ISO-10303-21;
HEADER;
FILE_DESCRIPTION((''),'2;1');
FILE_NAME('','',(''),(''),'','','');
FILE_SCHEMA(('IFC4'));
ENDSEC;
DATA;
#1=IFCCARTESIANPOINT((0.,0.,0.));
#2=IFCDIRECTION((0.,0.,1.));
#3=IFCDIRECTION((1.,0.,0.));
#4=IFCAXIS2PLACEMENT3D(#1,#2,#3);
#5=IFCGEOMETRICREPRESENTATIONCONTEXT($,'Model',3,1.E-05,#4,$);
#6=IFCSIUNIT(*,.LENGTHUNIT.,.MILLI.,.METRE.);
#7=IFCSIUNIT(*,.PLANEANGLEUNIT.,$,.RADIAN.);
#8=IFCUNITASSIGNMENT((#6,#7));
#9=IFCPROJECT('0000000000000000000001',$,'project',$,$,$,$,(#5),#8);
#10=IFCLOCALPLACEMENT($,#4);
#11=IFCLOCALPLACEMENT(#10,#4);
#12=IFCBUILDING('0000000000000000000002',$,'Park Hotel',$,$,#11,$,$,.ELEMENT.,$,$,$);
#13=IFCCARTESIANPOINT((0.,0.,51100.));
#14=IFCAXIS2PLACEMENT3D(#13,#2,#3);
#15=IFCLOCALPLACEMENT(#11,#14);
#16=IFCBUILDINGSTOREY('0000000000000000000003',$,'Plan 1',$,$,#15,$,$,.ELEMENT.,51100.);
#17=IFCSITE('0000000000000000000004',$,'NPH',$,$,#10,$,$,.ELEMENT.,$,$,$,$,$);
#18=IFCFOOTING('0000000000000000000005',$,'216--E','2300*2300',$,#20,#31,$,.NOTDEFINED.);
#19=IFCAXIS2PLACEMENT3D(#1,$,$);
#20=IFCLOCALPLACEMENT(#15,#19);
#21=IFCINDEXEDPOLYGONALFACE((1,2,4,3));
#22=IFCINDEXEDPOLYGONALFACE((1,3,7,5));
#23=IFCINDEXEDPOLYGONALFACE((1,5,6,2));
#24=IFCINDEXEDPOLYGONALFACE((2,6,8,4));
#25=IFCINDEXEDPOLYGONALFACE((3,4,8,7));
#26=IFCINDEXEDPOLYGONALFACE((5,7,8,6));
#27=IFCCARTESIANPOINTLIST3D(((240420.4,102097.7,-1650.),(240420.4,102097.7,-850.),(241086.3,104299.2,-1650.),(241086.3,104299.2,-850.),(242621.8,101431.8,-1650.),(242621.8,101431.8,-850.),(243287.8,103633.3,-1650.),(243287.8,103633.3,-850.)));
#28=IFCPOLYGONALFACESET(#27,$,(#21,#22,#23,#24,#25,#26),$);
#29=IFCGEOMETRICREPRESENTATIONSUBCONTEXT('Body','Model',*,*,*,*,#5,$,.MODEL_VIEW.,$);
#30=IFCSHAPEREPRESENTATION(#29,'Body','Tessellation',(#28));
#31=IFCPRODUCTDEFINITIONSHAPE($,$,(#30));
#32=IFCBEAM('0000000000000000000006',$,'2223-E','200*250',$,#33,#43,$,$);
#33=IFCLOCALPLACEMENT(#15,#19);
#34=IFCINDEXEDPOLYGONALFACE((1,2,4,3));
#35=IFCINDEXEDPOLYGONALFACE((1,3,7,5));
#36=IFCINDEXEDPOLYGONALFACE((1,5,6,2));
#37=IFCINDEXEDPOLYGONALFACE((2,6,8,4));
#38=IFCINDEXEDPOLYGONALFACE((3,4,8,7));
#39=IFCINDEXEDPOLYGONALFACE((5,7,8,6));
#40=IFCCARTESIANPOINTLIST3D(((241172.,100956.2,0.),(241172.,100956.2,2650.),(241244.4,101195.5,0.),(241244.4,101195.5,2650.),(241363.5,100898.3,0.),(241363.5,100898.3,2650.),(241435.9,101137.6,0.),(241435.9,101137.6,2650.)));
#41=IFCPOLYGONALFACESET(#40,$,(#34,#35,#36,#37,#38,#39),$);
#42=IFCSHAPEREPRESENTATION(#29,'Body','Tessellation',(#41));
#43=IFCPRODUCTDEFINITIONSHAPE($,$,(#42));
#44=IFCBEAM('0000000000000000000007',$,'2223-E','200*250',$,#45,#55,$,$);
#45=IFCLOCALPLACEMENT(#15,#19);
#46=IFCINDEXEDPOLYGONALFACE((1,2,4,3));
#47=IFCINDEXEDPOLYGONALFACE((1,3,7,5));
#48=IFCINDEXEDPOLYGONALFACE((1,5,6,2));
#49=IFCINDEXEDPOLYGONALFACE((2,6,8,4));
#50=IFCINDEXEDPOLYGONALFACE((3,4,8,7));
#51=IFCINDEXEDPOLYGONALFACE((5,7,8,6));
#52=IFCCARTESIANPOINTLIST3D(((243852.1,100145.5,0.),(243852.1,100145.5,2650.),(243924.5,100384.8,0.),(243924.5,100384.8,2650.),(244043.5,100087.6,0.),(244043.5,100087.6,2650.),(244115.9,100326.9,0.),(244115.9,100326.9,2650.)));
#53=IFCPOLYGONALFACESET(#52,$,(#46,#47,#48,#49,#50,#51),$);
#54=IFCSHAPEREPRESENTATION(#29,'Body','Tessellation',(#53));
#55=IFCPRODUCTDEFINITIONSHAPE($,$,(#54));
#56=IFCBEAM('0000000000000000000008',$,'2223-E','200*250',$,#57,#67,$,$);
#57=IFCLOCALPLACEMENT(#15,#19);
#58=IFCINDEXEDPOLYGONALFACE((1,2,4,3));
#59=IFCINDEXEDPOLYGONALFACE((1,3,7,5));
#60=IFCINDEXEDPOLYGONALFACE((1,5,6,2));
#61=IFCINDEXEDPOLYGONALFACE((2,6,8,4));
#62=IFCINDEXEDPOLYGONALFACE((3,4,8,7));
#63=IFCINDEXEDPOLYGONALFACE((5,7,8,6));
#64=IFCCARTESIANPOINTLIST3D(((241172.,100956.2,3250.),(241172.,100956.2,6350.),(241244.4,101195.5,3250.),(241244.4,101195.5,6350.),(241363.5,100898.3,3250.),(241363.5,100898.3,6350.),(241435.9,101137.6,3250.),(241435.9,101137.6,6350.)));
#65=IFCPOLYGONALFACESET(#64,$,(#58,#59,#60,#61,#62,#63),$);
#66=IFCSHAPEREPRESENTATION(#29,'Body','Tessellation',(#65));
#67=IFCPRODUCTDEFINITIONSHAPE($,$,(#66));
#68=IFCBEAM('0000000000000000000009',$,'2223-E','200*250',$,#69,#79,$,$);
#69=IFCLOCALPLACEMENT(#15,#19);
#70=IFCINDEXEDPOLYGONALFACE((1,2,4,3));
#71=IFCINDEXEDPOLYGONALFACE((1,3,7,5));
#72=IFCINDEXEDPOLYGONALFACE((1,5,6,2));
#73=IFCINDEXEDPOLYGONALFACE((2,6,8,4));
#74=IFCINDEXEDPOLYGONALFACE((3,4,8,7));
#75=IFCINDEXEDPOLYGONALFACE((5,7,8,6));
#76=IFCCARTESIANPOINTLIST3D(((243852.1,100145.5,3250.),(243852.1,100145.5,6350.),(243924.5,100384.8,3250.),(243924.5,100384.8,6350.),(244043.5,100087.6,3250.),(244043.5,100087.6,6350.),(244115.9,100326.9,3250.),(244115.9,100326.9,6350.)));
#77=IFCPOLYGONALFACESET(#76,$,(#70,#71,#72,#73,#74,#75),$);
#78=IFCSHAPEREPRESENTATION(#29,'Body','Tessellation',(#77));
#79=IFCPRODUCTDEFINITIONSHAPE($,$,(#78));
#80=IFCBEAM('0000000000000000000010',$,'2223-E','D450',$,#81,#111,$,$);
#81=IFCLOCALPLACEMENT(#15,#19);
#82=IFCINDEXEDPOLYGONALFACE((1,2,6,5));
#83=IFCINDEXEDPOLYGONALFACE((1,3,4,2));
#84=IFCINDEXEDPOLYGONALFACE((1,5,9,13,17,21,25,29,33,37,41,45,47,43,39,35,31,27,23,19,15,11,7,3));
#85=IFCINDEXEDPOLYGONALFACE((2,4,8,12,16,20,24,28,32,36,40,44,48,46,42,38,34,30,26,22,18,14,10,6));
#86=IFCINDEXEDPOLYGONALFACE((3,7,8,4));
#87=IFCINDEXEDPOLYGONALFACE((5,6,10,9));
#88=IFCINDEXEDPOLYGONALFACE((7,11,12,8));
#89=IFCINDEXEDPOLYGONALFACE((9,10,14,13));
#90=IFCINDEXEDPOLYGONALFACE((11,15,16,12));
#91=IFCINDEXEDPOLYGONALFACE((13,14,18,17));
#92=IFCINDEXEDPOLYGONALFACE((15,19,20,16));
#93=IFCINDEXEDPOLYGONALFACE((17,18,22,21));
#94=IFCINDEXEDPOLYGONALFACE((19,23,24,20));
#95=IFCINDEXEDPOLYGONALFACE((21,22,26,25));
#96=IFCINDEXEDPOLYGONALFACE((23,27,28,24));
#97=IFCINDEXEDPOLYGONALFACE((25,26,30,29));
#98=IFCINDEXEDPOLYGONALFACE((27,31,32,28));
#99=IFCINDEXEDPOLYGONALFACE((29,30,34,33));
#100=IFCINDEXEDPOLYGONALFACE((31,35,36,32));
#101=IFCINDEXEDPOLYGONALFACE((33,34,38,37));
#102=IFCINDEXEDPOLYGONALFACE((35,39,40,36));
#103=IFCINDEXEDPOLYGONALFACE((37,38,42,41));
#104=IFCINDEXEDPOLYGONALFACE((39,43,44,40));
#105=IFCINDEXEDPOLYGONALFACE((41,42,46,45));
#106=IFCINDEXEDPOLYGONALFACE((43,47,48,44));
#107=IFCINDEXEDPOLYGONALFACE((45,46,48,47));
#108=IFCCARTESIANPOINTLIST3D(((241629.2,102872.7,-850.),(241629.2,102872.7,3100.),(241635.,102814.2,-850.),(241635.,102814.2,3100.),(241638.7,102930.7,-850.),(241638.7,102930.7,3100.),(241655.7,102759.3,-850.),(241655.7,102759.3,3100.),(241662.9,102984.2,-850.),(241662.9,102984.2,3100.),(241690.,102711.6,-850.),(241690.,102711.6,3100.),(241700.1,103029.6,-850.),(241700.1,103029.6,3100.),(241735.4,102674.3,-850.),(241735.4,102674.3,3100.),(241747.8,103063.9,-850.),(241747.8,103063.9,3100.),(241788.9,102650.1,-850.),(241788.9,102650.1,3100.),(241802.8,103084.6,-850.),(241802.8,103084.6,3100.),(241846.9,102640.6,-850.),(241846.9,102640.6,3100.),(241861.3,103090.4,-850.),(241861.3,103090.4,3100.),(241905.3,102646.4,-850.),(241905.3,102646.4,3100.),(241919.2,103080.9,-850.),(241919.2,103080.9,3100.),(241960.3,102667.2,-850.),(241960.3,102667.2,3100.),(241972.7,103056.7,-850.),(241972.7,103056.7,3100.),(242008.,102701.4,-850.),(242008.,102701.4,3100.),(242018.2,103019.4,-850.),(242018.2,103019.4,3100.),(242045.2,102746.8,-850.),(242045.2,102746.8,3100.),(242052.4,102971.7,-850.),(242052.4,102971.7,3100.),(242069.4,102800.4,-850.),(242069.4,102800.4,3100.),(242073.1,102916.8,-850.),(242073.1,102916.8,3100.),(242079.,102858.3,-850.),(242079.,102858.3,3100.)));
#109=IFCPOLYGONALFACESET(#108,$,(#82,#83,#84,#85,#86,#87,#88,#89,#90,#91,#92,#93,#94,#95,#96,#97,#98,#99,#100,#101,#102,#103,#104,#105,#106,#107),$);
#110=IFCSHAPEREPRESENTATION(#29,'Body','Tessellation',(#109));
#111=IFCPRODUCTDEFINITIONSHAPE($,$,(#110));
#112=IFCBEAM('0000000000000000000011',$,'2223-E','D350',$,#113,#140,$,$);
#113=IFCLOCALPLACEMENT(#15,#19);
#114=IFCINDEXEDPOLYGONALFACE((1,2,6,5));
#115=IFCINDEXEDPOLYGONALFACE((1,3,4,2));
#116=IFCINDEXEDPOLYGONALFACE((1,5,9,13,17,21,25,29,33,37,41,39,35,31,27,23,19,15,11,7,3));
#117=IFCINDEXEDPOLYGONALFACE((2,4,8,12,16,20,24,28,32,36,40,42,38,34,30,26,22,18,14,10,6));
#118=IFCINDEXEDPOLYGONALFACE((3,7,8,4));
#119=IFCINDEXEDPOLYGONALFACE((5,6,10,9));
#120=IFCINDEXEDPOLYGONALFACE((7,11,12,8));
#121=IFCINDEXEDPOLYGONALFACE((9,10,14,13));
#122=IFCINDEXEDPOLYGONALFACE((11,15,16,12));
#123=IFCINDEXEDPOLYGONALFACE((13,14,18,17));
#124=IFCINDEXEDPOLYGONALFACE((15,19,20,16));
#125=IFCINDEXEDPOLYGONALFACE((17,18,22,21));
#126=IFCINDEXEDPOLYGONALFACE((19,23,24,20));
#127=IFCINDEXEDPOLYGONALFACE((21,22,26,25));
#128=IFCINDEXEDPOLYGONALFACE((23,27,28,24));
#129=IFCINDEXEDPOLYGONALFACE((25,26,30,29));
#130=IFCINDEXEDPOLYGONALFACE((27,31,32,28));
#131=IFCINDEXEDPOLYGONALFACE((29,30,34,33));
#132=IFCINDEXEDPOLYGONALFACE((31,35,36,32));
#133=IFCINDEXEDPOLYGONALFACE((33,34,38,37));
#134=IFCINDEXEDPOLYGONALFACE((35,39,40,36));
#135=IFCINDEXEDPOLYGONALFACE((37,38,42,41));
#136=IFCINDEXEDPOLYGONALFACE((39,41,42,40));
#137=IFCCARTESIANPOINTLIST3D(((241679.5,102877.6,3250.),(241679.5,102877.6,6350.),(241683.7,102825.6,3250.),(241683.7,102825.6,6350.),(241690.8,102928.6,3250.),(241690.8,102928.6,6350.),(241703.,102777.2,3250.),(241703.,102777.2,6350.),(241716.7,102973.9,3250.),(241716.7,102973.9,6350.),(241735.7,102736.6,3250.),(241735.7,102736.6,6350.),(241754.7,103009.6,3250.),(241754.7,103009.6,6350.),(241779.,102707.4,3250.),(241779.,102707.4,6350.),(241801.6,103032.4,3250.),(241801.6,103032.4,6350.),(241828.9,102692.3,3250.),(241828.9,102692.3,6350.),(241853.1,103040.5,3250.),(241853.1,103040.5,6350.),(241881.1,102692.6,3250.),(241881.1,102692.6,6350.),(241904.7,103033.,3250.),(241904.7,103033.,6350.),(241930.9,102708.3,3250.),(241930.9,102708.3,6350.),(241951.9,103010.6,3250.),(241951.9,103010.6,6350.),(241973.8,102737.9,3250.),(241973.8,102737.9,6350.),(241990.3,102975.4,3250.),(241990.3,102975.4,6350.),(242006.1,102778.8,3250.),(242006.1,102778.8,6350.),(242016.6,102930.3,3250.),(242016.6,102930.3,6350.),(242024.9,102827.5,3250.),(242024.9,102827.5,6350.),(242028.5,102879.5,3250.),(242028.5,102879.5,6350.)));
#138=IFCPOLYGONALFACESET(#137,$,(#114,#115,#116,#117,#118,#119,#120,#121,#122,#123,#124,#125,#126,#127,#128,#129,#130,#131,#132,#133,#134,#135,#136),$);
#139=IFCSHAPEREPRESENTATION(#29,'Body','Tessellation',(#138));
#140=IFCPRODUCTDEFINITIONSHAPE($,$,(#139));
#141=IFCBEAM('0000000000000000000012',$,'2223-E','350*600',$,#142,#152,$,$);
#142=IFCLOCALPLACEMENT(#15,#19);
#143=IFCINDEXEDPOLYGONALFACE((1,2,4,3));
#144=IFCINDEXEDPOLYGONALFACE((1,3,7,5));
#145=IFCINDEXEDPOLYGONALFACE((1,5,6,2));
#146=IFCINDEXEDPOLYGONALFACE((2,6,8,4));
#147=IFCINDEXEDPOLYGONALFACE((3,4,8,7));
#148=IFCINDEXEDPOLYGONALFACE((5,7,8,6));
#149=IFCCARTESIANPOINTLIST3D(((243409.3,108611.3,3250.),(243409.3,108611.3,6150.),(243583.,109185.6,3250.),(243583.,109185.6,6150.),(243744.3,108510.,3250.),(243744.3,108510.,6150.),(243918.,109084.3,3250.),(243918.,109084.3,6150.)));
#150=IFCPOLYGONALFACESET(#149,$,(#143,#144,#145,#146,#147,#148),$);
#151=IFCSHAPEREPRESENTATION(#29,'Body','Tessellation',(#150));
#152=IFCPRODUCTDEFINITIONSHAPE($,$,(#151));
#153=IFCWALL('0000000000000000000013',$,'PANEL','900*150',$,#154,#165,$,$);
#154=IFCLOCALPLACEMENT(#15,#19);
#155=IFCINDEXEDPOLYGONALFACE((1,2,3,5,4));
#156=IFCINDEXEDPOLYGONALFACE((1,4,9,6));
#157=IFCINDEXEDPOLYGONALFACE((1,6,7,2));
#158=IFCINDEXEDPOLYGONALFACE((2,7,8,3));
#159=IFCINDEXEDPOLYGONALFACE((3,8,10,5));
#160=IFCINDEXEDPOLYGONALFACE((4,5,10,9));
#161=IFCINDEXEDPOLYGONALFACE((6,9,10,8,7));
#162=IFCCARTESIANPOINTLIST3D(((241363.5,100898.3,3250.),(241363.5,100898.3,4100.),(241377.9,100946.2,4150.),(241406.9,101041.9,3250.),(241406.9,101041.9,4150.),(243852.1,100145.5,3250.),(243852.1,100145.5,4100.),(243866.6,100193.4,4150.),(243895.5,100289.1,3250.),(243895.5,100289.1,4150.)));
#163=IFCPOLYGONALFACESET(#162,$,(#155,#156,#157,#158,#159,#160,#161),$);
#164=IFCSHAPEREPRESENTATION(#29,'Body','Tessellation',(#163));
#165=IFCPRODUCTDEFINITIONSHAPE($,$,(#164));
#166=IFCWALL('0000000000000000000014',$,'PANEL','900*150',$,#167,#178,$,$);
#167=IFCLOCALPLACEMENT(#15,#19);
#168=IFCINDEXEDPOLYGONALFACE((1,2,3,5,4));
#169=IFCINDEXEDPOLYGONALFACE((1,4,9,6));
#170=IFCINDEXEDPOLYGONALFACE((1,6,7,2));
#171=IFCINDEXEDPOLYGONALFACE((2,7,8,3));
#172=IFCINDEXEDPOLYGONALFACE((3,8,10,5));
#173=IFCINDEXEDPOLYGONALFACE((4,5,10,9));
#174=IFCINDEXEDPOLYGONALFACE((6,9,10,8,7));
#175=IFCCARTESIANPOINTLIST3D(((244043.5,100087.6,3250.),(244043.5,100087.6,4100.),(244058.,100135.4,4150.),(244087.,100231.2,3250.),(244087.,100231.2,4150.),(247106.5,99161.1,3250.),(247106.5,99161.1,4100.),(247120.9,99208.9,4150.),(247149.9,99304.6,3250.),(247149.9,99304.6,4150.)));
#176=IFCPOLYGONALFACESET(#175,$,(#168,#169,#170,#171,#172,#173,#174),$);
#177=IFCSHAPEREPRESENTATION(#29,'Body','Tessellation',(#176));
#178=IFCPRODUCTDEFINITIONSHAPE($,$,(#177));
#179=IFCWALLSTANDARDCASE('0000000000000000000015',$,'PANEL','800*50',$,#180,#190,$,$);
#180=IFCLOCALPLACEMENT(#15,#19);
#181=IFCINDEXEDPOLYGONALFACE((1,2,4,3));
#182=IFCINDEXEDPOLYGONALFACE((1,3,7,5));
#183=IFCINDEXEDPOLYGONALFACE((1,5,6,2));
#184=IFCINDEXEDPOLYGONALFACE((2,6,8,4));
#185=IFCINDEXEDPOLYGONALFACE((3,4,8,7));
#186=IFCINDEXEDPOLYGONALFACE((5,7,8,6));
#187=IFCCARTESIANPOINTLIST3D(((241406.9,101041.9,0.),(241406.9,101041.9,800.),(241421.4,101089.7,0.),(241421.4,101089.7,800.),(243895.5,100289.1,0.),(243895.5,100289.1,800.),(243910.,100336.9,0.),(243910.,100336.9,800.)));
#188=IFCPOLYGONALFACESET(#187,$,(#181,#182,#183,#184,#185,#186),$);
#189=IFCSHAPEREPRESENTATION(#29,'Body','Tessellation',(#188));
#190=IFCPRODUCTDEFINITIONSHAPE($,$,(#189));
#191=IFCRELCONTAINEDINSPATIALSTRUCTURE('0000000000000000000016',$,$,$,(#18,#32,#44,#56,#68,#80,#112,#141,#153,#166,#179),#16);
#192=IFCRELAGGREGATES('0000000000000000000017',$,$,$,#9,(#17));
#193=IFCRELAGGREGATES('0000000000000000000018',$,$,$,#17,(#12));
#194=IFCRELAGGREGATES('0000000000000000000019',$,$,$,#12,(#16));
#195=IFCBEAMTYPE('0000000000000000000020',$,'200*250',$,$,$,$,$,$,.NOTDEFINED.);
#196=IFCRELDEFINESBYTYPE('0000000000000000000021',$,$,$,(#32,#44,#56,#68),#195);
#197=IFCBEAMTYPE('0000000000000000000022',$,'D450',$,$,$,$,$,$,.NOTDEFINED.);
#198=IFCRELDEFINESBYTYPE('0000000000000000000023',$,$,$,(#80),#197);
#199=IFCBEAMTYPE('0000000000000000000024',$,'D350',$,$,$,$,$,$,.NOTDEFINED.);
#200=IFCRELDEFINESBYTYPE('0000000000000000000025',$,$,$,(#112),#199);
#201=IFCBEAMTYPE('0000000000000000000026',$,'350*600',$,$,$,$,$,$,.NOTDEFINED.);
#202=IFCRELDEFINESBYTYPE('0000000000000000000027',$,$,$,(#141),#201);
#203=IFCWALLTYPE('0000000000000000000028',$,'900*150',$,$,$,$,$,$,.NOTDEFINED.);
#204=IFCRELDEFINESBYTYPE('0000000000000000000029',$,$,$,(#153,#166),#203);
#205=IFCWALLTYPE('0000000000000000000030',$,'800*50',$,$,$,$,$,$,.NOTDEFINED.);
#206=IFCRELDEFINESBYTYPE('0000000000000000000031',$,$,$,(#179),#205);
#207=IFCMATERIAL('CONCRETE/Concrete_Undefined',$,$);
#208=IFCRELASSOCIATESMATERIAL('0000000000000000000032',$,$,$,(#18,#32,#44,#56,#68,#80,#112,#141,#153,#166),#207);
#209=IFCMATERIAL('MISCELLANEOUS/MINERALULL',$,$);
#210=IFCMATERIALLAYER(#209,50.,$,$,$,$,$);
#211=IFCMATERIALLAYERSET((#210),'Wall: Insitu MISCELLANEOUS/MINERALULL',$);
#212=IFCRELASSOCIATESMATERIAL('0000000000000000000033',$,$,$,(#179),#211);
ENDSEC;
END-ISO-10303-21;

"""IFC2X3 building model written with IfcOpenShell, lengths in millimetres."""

from ifc_helpers import new_model, si_unit, frame, frame_2d, origin_with_axes, origin_2d_with_axis, place, context, subcontext, project, spatial, rectangle, circle, extrude, clip, halfspace, material, layer, layer_set, layer_usage, type_object, element, save


model = new_model("IFC2X3")

# Units and contexts
model_context = context("Model", 3, precision=1e-05, world=origin_with_axes())
body_context = subcontext(model_context, "Body", "Model", "MODEL_VIEW")
ifc_project = project(units=[si_unit("LENGTHUNIT", "METRE", prefix="MILLI"), si_unit("PLANEANGLEUNIT", "RADIAN")], contexts=[model_context])

# Site, building, storey
site_placement = place(None, origin_with_axes())
site = spatial("IfcSite", under=ifc_project, at=site_placement, Name="NPH", CompositionType="ELEMENT")
building_placement = place(site_placement, origin_with_axes())
building = spatial("IfcBuilding", under=site, at=building_placement, Name="Park Hotel", CompositionType="ELEMENT")
storey_placement = place(building_placement, frame((0.0, 0.0, 51100.0), z_axis=(0.0, 0.0, 1.0), x_axis=(1.0, 0.0, 0.0)))
storey = spatial("IfcBuildingStorey", under=building, at=storey_placement, Name="Plan 1", CompositionType="ELEMENT", Elevation=51100.0)

# Footing
ifc_material_1 = material(Name="CONCRETE/Concrete_Undefined")
footing_placement = place(storey_placement, frame((241854.1, 102865.5, -1650.0), z_axis=(0.289538, 0.957167, 0.0), x_axis=(0.0, 0.0, 1.0)))
element("IfcFooting", 1, at=footing_placement, inside=storey, material=ifc_material_1, Name="216--E", Description="2300*2300", PredefinedType="NOTDEFINED", context=body_context, shape_type="SweptSolid", body=[
    extrude(rectangle(XDim=2300.0, YDim=2300.0, at=origin_2d_with_axis()), frame((800.0, 0.0, 0.0), z_axis=(-1.0, 0.0, 0.0), x_axis=(0.0, -1.0, 0.0)), (0.0, 0.0, 1.0), 800.0),
])

# Beams
beam_type_1 = type_object("IfcBeamType", Name="200*250", PredefinedType="NOTDEFINED")
for number, where, z_axis, x_axis, name in (
    (2, (241303.9, 101046.9, 0.0), (0.957167, -0.289538, 0.0), (0.0, 0.0, 1.0), "2223-E"),
    (3, (243984.0, 100236.2, 0.0), (0.957167, -0.289538, 0.0), (0.0, 0.0, 1.0), "2223-E"),
):
    element("IfcBeam", number, at=place(storey_placement, frame(where, z_axis=z_axis, x_axis=x_axis)), inside=storey, type_object=beam_type_1, material=ifc_material_1, Name=name, Description="200*250", context=body_context, shape_type="SweptSolid", body=[
        extrude(rectangle(XDim=250.0, YDim=200.0, at=origin_2d_with_axis()), frame((2650.0, 0.0, 0.0), z_axis=(-1.0, 0.0, 0.0), x_axis=(0.0, -1.0, 0.0)), (0.0, 0.0, 1.0), 2650.0),
    ])
for number, where, z_axis, x_axis, name in (
    (4, (241303.9, 101046.9, 3250.0), (0.957167, -0.289538, 0.0), (0.0, 0.0, 1.0), "2223-E"),
    (5, (243984.0, 100236.2, 3250.0), (0.957167, -0.289538, 0.0), (0.0, 0.0, 1.0), "2223-E"),
):
    element("IfcBeam", number, at=place(storey_placement, frame(where, z_axis=z_axis, x_axis=x_axis)), inside=storey, type_object=beam_type_1, material=ifc_material_1, Name=name, Description="200*250", context=body_context, shape_type="SweptSolid", body=[
        extrude(rectangle(XDim=250.0, YDim=200.0, at=origin_2d_with_axis()), frame((3100.0, 0.0, 0.0), z_axis=(-1.0, 0.0, 0.0), x_axis=(0.0, -1.0, 0.0)), (0.0, 0.0, 1.0), 3100.0),
    ])
beam_type_2 = type_object("IfcBeamType", Name="D450", PredefinedType="NOTDEFINED")
beam_1_placement = place(storey_placement, frame((241854.1, 102865.5, -850.0), z_axis=(0.957167, -0.289538, 0.0), x_axis=(0.0, 0.0, 1.0)))
element("IfcBeam", 6, at=beam_1_placement, inside=storey, type_object=beam_type_2, material=ifc_material_1, Name="2223-E", Description="D450", context=body_context, shape_type="SweptSolid", body=[
    extrude(circle(Radius=225.0, at=origin_2d_with_axis()), frame((3950.0, 0.0, 0.0), z_axis=(-1.0, 0.0, 0.0), x_axis=(0.0, -1.0, 0.0)), (0.0, 0.0, 1.0), 3950.0),
])
beam_type_3 = type_object("IfcBeamType", Name="D350", PredefinedType="NOTDEFINED")
beam_2_placement = place(storey_placement, frame((241854.1, 102865.5, 3250.0), z_axis=(0.957167, -0.289538, 0.0), x_axis=(0.0, 0.0, 1.0)))
element("IfcBeam", 7, at=beam_2_placement, inside=storey, type_object=beam_type_3, material=ifc_material_1, Name="2223-E", Description="D350", context=body_context, shape_type="SweptSolid", body=[
    extrude(circle(Radius=175.0, at=origin_2d_with_axis()), frame((3100.0, 0.0, 0.0), z_axis=(-1.0, 0.0, 0.0), x_axis=(0.0, -1.0, 0.0)), (0.0, 0.0, 1.0), 3100.0),
])
beam_type_4 = type_object("IfcBeamType", Name="350*600", PredefinedType="NOTDEFINED")
beam_3_placement = place(storey_placement, frame((243663.7, 108847.8, 3250.0), z_axis=(0.957167, -0.289538, 0.0), x_axis=(0.0, 0.0, 1.0)))
element("IfcBeam", 8, at=beam_3_placement, inside=storey, type_object=beam_type_4, material=ifc_material_1, Name="2223-E", Description="350*600", context=body_context, shape_type="SweptSolid", body=[
    extrude(rectangle(XDim=600.0, YDim=350.0, at=origin_2d_with_axis()), frame((2900.0, 0.0, 0.0), z_axis=(-1.0, 0.0, 0.0), x_axis=(0.0, -1.0, 0.0)), (0.0, 0.0, 1.0), 2900.0),
])

# Walls
wall_type_1 = type_object("IfcWallType", Name="900*150", PredefinedType="NOTDEFINED")
wall_1_placement = place(storey_placement, frame((241385.2, 100970.1, 3250.0), z_axis=(0.0, 0.0, 1.0), x_axis=(0.957166, -0.289539, 0.0)))
element("IfcWall", 9, at=wall_1_placement, inside=storey, type_object=wall_type_1, material=ifc_material_1, Name="PANEL", Description="900*150", context=body_context, shape_type="Clipping", body=[
    clip(extrude(rectangle(XDim=2600.0, YDim=150.0, at=frame_2d((0.0, 1300.0), x_axis=(0.0, -1.0))), frame((0.0, 0.0, 0.0), z_axis=(0.0, 0.0, 1.0), x_axis=(0.0, -1.0, 0.0)), (0.0, 0.0, 1.0), 900.0), halfspace(frame((2600.0, 75.0, 1000.0), z_axis=(0.000001, -0.707072, 0.707141), x_axis=(0.0, -0.707141, -0.707072)), False)),
])
wall_2_placement = place(storey_placement, frame((244065.2, 100159.4, 3250.0), z_axis=(0.0, 0.0, 1.0), x_axis=(0.957166, -0.289539, 0.0)))
element("IfcWall", 10, at=wall_2_placement, inside=storey, type_object=wall_type_1, material=ifc_material_1, Name="PANEL", Description="900*150", context=body_context, shape_type="Clipping", body=[
    clip(extrude(rectangle(XDim=3200.0, YDim=150.0, at=frame_2d((0.0, 1600.0), x_axis=(0.0, -1.0))), frame((0.0, 0.0, 0.0), z_axis=(0.0, 0.0, 1.0), x_axis=(0.0, -1.0, 0.0)), (0.0, 0.0, 1.0), 900.0), halfspace(frame((3200.0, 75.0, 1000.0), z_axis=(0.000001, -0.707072, 0.707141), x_axis=(0.0, -0.707141, -0.707072)), False)),
])
ifc_material_2 = material(Name="MISCELLANEOUS/MINERALULL")
ifc_layer_1 = layer(ifc_material_2, 50.0)
ifc_layer_set_1 = layer_set([ifc_layer_1], Name="Wall: Insitu MISCELLANEOUS/MINERALULL")
ifc_layer_usage_1 = layer_usage(ifc_layer_set_1, "AXIS2", "POSITIVE", -25.0)
wall_type_2 = type_object("IfcWallType", Name="800*50", PredefinedType="NOTDEFINED")
wall_3_placement = place(storey_placement, frame((241414.1, 101065.8, 0.0), z_axis=(0.0, 0.0, 1.0), x_axis=(0.957166, -0.289539, 0.0)))
element("IfcWallStandardCase", 11, at=wall_3_placement, inside=storey, type_object=wall_type_2, material=ifc_layer_usage_1, Name="PANEL", Description="800*50", context=body_context, shape_type="SweptSolid", body=[
    extrude(rectangle(XDim=2600.0, YDim=50.0, at=frame_2d((0.0, 1300.0), x_axis=(0.0, -1.0))), frame((0.0, 0.0, 0.0), z_axis=(0.0, 0.0, 1.0), x_axis=(0.0, -1.0, 0.0)), (0.0, 0.0, 1.0), 800.0),
])

save(model, "model.ifc")
